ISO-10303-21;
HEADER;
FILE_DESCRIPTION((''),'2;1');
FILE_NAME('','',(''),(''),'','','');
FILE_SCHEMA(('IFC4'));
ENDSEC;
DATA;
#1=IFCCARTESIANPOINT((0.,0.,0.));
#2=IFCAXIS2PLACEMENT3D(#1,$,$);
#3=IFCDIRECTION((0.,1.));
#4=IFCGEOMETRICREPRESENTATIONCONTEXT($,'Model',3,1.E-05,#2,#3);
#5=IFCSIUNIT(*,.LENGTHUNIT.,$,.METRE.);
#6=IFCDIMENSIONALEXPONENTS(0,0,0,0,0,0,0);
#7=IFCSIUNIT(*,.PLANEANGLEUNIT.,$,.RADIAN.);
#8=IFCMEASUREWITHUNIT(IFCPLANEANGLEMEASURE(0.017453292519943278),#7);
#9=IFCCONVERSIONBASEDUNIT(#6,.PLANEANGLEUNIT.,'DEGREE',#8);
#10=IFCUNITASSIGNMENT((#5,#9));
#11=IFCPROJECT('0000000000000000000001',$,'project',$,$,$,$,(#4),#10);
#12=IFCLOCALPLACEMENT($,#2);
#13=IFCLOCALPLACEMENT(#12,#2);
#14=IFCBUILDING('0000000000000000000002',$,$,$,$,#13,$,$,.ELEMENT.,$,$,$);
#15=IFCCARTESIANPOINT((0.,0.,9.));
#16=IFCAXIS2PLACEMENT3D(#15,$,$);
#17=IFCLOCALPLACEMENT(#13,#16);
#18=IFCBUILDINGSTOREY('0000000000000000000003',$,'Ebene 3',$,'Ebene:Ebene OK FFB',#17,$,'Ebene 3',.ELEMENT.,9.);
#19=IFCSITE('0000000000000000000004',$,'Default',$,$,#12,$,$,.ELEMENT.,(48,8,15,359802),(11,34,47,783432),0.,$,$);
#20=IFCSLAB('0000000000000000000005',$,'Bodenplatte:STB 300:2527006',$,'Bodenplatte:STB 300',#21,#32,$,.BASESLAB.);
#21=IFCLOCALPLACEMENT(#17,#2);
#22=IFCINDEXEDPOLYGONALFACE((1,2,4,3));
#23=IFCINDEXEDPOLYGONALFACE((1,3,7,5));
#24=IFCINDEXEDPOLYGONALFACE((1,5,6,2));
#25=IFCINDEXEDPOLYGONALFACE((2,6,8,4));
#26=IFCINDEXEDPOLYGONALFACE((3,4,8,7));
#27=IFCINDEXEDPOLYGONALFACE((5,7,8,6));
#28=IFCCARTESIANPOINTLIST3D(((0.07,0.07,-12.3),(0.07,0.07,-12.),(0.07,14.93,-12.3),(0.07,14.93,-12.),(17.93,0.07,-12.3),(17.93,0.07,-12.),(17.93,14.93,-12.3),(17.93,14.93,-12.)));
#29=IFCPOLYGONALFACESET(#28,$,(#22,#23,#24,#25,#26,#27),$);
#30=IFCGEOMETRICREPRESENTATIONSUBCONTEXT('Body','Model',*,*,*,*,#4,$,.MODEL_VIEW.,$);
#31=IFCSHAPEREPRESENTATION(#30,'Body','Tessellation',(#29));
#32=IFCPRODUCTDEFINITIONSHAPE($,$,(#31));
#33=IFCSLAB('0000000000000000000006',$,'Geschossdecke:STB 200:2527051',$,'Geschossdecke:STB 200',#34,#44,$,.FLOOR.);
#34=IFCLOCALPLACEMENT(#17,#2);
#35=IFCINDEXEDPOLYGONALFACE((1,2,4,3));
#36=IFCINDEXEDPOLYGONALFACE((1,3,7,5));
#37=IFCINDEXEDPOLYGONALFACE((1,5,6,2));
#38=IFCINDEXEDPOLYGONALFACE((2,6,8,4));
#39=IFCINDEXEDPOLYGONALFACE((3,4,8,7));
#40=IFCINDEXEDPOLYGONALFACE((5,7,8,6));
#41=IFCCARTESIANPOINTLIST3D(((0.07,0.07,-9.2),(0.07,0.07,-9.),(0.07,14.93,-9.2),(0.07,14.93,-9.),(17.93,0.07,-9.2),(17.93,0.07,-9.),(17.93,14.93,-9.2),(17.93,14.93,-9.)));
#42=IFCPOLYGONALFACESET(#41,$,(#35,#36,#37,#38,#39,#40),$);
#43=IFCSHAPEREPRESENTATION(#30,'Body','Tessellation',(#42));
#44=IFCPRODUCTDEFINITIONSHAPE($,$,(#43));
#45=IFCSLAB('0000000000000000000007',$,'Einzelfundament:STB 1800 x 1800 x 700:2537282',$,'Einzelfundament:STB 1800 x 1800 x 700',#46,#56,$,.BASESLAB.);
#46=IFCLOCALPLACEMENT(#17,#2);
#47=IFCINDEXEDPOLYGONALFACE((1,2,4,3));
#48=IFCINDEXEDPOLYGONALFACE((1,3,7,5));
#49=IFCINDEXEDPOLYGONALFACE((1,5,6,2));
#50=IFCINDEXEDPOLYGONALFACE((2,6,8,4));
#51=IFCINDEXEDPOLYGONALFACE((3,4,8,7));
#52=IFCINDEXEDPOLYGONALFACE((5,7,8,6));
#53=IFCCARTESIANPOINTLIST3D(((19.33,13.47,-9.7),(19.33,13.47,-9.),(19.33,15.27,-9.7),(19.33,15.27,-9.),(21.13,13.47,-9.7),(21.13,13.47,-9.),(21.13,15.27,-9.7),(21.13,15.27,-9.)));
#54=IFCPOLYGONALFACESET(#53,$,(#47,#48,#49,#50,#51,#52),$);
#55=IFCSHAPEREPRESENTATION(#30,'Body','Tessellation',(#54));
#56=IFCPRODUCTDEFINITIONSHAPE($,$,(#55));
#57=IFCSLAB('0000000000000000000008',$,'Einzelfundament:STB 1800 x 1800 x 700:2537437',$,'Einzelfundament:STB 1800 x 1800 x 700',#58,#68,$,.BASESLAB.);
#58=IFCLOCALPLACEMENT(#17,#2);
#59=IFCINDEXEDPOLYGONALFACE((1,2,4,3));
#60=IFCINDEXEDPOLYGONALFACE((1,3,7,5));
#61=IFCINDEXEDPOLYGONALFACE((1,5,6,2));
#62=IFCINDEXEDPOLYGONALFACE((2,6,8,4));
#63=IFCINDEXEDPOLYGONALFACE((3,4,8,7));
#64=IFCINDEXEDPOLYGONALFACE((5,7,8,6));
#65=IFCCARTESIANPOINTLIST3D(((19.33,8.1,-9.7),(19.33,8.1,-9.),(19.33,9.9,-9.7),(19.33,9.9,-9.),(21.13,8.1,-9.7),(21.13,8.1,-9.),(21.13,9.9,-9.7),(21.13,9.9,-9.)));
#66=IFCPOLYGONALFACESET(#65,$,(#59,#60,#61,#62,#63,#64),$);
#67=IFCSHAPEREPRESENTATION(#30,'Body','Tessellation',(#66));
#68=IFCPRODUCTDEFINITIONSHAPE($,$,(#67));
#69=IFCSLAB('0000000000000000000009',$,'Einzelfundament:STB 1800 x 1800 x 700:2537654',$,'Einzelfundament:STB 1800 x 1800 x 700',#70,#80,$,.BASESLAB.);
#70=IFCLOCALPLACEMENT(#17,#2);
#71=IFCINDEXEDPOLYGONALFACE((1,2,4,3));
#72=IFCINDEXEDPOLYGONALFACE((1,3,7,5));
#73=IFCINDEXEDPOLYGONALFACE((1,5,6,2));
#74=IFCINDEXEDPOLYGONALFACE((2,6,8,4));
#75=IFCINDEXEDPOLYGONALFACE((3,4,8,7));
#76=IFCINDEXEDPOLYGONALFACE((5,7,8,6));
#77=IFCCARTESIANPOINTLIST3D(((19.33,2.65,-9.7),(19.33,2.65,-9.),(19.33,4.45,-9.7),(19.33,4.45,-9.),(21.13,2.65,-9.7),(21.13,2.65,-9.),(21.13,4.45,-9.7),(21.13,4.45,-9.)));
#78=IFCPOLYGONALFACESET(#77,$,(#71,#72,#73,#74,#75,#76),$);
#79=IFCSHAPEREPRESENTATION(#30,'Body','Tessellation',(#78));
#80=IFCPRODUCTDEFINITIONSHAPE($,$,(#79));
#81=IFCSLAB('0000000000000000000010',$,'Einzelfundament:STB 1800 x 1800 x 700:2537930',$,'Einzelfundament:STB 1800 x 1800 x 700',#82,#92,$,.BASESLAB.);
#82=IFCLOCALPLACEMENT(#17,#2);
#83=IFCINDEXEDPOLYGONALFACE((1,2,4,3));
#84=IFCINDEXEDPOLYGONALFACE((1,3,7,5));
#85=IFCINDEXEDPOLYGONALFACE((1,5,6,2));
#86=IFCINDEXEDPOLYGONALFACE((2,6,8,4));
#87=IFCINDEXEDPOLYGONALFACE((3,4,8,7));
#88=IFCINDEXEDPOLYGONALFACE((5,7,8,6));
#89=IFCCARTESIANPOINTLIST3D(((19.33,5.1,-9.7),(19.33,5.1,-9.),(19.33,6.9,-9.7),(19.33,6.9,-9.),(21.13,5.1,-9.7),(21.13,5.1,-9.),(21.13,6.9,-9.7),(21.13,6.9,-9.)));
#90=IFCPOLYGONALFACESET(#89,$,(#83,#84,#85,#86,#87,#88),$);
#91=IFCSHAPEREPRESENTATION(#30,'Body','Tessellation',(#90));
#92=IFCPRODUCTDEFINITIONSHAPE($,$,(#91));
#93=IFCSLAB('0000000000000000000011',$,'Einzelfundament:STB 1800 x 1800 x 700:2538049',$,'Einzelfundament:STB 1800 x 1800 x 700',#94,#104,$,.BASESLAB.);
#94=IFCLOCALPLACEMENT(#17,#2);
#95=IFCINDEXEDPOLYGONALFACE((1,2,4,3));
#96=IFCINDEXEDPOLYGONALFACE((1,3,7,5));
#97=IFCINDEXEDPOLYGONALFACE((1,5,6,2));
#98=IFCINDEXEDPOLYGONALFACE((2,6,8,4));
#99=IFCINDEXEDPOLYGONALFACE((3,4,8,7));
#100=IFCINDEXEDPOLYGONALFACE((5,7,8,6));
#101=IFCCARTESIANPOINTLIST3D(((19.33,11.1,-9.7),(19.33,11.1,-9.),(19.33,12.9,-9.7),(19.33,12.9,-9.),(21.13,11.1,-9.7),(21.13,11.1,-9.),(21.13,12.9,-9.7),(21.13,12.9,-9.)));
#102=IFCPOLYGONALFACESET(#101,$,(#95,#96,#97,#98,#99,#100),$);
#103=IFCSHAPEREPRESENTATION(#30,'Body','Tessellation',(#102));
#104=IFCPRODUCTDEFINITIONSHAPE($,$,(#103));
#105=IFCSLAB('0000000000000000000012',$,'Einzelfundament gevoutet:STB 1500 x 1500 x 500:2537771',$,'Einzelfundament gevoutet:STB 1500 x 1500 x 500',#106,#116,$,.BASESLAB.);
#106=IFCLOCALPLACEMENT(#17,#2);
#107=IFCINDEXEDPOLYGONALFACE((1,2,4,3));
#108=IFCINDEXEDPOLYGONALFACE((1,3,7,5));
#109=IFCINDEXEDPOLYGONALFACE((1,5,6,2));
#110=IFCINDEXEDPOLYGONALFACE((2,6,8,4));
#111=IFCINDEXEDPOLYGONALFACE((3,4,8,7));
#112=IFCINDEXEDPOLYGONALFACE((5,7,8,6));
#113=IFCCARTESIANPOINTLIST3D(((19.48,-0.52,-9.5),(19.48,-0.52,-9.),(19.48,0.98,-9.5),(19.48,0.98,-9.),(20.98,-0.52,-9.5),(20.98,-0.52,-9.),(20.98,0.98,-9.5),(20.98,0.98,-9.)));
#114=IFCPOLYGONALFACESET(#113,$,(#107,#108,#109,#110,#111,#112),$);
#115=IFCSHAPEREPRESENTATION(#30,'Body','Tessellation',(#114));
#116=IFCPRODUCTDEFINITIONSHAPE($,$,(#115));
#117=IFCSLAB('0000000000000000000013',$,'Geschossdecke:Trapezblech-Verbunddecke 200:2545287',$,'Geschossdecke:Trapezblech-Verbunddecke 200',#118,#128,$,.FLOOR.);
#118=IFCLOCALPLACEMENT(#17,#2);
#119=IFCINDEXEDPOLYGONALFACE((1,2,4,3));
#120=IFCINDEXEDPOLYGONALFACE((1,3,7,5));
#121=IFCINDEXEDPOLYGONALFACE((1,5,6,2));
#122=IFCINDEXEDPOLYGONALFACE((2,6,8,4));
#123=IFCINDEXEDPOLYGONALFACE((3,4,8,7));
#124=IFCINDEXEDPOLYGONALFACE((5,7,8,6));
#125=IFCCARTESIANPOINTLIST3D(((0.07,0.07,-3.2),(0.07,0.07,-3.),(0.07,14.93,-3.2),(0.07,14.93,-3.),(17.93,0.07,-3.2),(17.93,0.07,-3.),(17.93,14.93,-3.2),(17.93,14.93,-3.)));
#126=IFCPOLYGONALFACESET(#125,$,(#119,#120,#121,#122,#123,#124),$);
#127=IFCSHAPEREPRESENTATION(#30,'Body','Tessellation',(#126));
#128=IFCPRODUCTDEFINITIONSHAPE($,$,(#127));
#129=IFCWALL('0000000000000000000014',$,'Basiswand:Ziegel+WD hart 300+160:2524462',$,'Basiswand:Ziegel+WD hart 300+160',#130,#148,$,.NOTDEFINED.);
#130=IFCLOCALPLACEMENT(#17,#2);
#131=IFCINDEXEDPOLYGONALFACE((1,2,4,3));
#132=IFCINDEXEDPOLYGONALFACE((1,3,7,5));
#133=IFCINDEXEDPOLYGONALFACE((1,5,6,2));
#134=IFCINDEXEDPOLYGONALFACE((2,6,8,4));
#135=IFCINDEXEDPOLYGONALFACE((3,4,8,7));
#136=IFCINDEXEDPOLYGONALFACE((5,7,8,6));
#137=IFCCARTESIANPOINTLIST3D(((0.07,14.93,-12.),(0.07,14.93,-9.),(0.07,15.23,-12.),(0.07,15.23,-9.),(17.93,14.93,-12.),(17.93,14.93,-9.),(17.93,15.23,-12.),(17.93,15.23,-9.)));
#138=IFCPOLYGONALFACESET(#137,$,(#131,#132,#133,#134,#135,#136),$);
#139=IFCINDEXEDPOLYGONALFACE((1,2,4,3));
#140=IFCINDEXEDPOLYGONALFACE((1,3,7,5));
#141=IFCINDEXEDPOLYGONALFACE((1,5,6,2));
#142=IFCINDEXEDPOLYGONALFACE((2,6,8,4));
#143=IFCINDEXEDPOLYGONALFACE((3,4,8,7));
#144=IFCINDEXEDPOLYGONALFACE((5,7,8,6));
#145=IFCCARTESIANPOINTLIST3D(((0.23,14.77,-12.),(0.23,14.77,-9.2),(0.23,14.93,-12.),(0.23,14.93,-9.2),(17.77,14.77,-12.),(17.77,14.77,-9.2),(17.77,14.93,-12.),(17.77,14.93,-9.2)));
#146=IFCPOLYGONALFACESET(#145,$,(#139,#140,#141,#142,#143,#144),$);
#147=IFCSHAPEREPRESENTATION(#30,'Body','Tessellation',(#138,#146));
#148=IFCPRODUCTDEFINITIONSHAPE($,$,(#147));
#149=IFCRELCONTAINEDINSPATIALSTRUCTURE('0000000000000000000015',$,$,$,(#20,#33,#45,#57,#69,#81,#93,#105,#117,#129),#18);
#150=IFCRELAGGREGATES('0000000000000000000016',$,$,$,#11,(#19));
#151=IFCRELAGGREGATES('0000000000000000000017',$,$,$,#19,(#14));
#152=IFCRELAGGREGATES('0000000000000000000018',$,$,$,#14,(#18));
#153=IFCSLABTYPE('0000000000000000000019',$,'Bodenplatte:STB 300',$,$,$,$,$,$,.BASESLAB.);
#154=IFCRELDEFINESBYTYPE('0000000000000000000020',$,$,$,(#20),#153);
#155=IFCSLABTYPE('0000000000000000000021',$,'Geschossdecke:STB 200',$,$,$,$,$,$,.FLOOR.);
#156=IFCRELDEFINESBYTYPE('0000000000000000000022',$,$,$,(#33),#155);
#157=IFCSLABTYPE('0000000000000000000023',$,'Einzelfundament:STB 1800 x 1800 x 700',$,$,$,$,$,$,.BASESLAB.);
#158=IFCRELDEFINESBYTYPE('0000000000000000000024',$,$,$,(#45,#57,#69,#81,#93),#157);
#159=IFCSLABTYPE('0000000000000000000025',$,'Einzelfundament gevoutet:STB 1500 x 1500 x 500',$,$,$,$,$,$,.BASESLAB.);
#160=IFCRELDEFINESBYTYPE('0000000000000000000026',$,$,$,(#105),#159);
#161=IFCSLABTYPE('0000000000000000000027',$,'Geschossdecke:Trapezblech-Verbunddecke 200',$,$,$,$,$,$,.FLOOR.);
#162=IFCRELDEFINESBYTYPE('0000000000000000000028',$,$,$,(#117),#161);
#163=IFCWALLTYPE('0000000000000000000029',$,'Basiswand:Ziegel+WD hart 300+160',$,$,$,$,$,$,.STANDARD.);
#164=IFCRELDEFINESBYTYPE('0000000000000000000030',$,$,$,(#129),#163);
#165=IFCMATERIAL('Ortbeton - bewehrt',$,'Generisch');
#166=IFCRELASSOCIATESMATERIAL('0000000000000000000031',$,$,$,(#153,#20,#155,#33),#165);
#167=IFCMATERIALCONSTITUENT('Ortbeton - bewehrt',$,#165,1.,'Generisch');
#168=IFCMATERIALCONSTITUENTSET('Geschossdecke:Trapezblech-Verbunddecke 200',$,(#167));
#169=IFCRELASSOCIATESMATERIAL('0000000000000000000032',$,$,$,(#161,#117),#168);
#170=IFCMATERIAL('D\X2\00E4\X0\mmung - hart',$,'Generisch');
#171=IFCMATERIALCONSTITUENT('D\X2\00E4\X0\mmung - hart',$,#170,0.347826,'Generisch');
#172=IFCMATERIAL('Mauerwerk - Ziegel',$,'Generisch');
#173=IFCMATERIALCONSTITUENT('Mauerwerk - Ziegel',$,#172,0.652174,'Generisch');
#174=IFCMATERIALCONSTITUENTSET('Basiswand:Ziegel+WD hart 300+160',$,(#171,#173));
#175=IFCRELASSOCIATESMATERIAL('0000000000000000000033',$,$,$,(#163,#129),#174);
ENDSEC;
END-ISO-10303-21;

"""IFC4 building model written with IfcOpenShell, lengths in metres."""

from ifc_helpers import new_model, entity, si_unit, converted_unit, direction, frame, origin, place, context, subcontext, project, spatial, indexed_curve, outline, extrude, material, constituent, constituent_set, type_object, element, save


model = new_model("IFC4")

# Units and contexts
model_context = context("Model", 3, precision=1e-05, world=origin(), true_north=direction((0.0, 1.0)))
body_context = subcontext(model_context, "Body", "Model", "MODEL_VIEW")
ifc_project = project(units=[si_unit("LENGTHUNIT", "METRE"), converted_unit("PLANEANGLEUNIT", "DEGREE", entity("IfcPlaneAngleMeasure", 0.017453292519943278), si_unit("PLANEANGLEUNIT", "RADIAN"), dimensions=[0, 0, 0, 0, 0, 0, 0])], contexts=[model_context])

# Site, building, storey
site_placement = place(None, origin())
site = spatial("IfcSite", under=ifc_project, at=site_placement, Name="Default", CompositionType="ELEMENT", RefLatitude=(48, 8, 15, 359802), RefLongitude=(11, 34, 47, 783432), RefElevation=0.0)
building_placement = place(site_placement, origin())
building = spatial("IfcBuilding", under=site, at=building_placement, CompositionType="ELEMENT")
storey_placement = place(building_placement, frame((0.0, 0.0, 9.0)))
storey = spatial("IfcBuildingStorey", under=building, at=storey_placement, Name="Ebene 3", ObjectType="Ebene:Ebene OK FFB", LongName="Ebene 3", CompositionType="ELEMENT", Elevation=9.0)

# Slabs
ifc_material_1 = material(Name="Ortbeton - bewehrt", Category="Generisch")
slab_type_1 = type_object("IfcSlabType", Name="Bodenplatte:STB 300", PredefinedType="BASESLAB", material=ifc_material_1)
slab_1_placement = place(storey_placement, origin())
element("IfcSlab", 1, at=slab_1_placement, inside=storey, type_object=slab_type_1, material=ifc_material_1, Name="Bodenplatte:STB 300:2527006", ObjectType="Bodenplatte:STB 300", PredefinedType="BASESLAB", context=body_context, shape_type="SweptSolid", body=[
    extrude(outline(indexed_curve([(-7.43, -8.93), (7.43, -8.93), (7.43, 8.93), (-7.43, 8.93), (-7.43, -8.93)], self_intersect=False)), frame((9.0, 7.5, -12.0), z_axis=(0.0, 0.0, -1.0), x_axis=(0.0, 1.0, 0.0)), (0.0, 0.0, 1.0), 0.3),
])
slab_type_2 = type_object("IfcSlabType", Name="Geschossdecke:STB 200", PredefinedType="FLOOR", material=ifc_material_1)
slab_2_placement = place(storey_placement, origin())
element("IfcSlab", 2, at=slab_2_placement, inside=storey, type_object=slab_type_2, material=ifc_material_1, Name="Geschossdecke:STB 200:2527051", ObjectType="Geschossdecke:STB 200", PredefinedType="FLOOR", context=body_context, shape_type="SweptSolid", body=[
    extrude(outline(indexed_curve([(-7.43, -8.93), (7.43, -8.93), (7.43, 8.93), (-7.43, 8.93), (-7.43, -8.93)], self_intersect=False)), frame((9.0, 7.5, -9.0), z_axis=(0.0, 0.0, -1.0), x_axis=(0.0, 1.0, 0.0)), (0.0, 0.0, 1.0), 0.2),
])

# Slabs
slab_type_3 = type_object("IfcSlabType", Name="Einzelfundament:STB 1800 x 1800 x 700", PredefinedType="BASESLAB")
slab_3_placement = place(storey_placement, origin())
element("IfcSlab", 3, at=slab_3_placement, inside=storey, type_object=slab_type_3, Name="Einzelfundament:STB 1800 x 1800 x 700:2537282", ObjectType="Einzelfundament:STB 1800 x 1800 x 700", PredefinedType="BASESLAB", context=body_context, shape_type="SweptSolid", body=[
    extrude(outline(indexed_curve([(-0.9, -0.9), (0.9, -0.9), (0.9, 0.9), (-0.9, 0.9), (-0.9, -0.9)], self_intersect=False)), frame((20.23, 14.37, -9.7), z_axis=(0.0, 0.0, 1.0), x_axis=(-1.0, 0.0, 0.0)), (0.0, 0.0, 1.0), 0.7),
])
slab_4_placement = place(storey_placement, origin())
element("IfcSlab", 4, at=slab_4_placement, inside=storey, type_object=slab_type_3, Name="Einzelfundament:STB 1800 x 1800 x 700:2537437", ObjectType="Einzelfundament:STB 1800 x 1800 x 700", PredefinedType="BASESLAB", context=body_context, shape_type="SweptSolid", body=[
    extrude(outline(indexed_curve([(-0.9, -0.9), (0.9, -0.9), (0.9, 0.9), (-0.9, 0.9), (-0.9, -0.9)], self_intersect=False)), frame((20.23, 9.0, -9.7), z_axis=(0.0, 0.0, 1.0), x_axis=(-1.0, 0.0, 0.0)), (0.0, 0.0, 1.0), 0.7),
])
slab_5_placement = place(storey_placement, origin())
element("IfcSlab", 5, at=slab_5_placement, inside=storey, type_object=slab_type_3, Name="Einzelfundament:STB 1800 x 1800 x 700:2537654", ObjectType="Einzelfundament:STB 1800 x 1800 x 700", PredefinedType="BASESLAB", context=body_context, shape_type="SweptSolid", body=[
    extrude(outline(indexed_curve([(-0.9, -0.9), (0.9, -0.9), (0.9, 0.9), (-0.9, 0.9), (-0.9, -0.9)], self_intersect=False)), frame((20.23, 3.55, -9.7), z_axis=(0.0, 0.0, 1.0), x_axis=(-1.0, 0.0, 0.0)), (0.0, 0.0, 1.0), 0.7),
])
slab_6_placement = place(storey_placement, origin())
element("IfcSlab", 6, at=slab_6_placement, inside=storey, type_object=slab_type_3, Name="Einzelfundament:STB 1800 x 1800 x 700:2537930", ObjectType="Einzelfundament:STB 1800 x 1800 x 700", PredefinedType="BASESLAB", context=body_context, shape_type="SweptSolid", body=[
    extrude(outline(indexed_curve([(-0.9, -0.9), (0.9, -0.9), (0.9, 0.9), (-0.9, 0.9), (-0.9, -0.9)], self_intersect=False)), frame((20.23, 6.0, -9.7), z_axis=(0.0, 0.0, 1.0), x_axis=(-1.0, 0.0, 0.0)), (0.0, 0.0, 1.0), 0.7),
])
slab_7_placement = place(storey_placement, origin())
element("IfcSlab", 7, at=slab_7_placement, inside=storey, type_object=slab_type_3, Name="Einzelfundament:STB 1800 x 1800 x 700:2538049", ObjectType="Einzelfundament:STB 1800 x 1800 x 700", PredefinedType="BASESLAB", context=body_context, shape_type="SweptSolid", body=[
    extrude(outline(indexed_curve([(-0.9, -0.9), (0.9, -0.9), (0.9, 0.9), (-0.9, 0.9), (-0.9, -0.9)], self_intersect=False)), frame((20.23, 12.0, -9.7), z_axis=(0.0, 0.0, 1.0), x_axis=(-1.0, 0.0, 0.0)), (0.0, 0.0, 1.0), 0.7),
])
slab_type_4 = type_object("IfcSlabType", Name="Einzelfundament gevoutet:STB 1500 x 1500 x 500", PredefinedType="BASESLAB")
slab_8_placement = place(storey_placement, origin())
element("IfcSlab", 8, at=slab_8_placement, inside=storey, type_object=slab_type_4, Name="Einzelfundament gevoutet:STB 1500 x 1500 x 500:2537771", ObjectType="Einzelfundament gevoutet:STB 1500 x 1500 x 500", PredefinedType="BASESLAB", context=body_context, shape_type="SweptSolid", body=[
    extrude(outline(indexed_curve([(-0.75, -0.75), (0.75, -0.75), (0.75, 0.75), (-0.75, 0.75), (-0.75, -0.75)], self_intersect=False)), frame((20.23, 0.23, -9.5), z_axis=(0.0, 0.0, 1.0), x_axis=(-1.0, 0.0, 0.0)), (0.0, 0.0, 1.0), 0.5),
])
ifc_constituent_1 = constituent(ifc_material_1, Name="Ortbeton - bewehrt", Category="Generisch", fraction=1.0)
ifc_constituent_set_1 = constituent_set(constituents=[ifc_constituent_1], Name="Geschossdecke:Trapezblech-Verbunddecke 200")
slab_type_5 = type_object("IfcSlabType", Name="Geschossdecke:Trapezblech-Verbunddecke 200", PredefinedType="FLOOR", material=ifc_constituent_set_1)
slab_9_placement = place(storey_placement, origin())
element("IfcSlab", 9, at=slab_9_placement, inside=storey, type_object=slab_type_5, material=ifc_constituent_set_1, Name="Geschossdecke:Trapezblech-Verbunddecke 200:2545287", ObjectType="Geschossdecke:Trapezblech-Verbunddecke 200", PredefinedType="FLOOR", context=body_context, shape_type="SweptSolid", body=[
    extrude(outline(indexed_curve([(-7.43, -8.93), (7.43, -8.93), (7.43, 8.93), (-7.43, 8.93), (-7.43, -8.93)], self_intersect=False)), frame((9.0, 7.5, -3.0), z_axis=(0.0, 0.0, -1.0), x_axis=(0.0, 1.0, 0.0)), (0.0, 0.0, 1.0), 0.2),
])

# Wall
ifc_material_2 = material(Name="Dämmung - hart", Category="Generisch")
ifc_constituent_2 = constituent(ifc_material_2, Name="Dämmung - hart", Category="Generisch", fraction=0.347826)
ifc_material_3 = material(Name="Mauerwerk - Ziegel", Category="Generisch")
ifc_constituent_3 = constituent(ifc_material_3, Name="Mauerwerk - Ziegel", Category="Generisch", fraction=0.652174)
ifc_constituent_set_2 = constituent_set(constituents=[ifc_constituent_2, ifc_constituent_3], Name="Basiswand:Ziegel+WD hart 300+160")
wall_type = type_object("IfcWallType", Name="Basiswand:Ziegel+WD hart 300+160", PredefinedType="STANDARD", material=ifc_constituent_set_2)
wall_1_placement = place(storey_placement, frame((17.77, 15.0, -12.0), z_axis=(0.0, 0.0, 1.0), x_axis=(-1.0, 0.0, 0.0)))
element("IfcWall", 10, at=wall_1_placement, inside=storey, type_object=wall_type, material=ifc_constituent_set_2, Name="Basiswand:Ziegel+WD hart 300+160:2524462", ObjectType="Basiswand:Ziegel+WD hart 300+160", PredefinedType="NOTDEFINED", context=body_context, shape_type="SweptSolid", body=[
    extrude(outline(indexed_curve([(-0.15, -8.93), (0.15, -8.93), (0.15, 8.93), (-0.15, 8.93), (-0.15, -8.93)], self_intersect=False)), frame((8.77, -0.08, 0.0), z_axis=(0.0, 0.0, 1.0), x_axis=(0.0, 1.0, 0.0)), (0.0, 0.0, 1.0), 3.0),
    extrude(outline(indexed_curve([(-0.08, -8.77), (0.08, -8.77), (0.08, 8.77), (-0.08, 8.77), (-0.08, -8.77)], self_intersect=False)), frame((8.77, 0.15, 0.0), z_axis=(0.0, 0.0, 1.0), x_axis=(0.0, -1.0, 0.0)), (0.0, 0.0, 1.0), 2.8),
])

save(model, "model.ifc")
